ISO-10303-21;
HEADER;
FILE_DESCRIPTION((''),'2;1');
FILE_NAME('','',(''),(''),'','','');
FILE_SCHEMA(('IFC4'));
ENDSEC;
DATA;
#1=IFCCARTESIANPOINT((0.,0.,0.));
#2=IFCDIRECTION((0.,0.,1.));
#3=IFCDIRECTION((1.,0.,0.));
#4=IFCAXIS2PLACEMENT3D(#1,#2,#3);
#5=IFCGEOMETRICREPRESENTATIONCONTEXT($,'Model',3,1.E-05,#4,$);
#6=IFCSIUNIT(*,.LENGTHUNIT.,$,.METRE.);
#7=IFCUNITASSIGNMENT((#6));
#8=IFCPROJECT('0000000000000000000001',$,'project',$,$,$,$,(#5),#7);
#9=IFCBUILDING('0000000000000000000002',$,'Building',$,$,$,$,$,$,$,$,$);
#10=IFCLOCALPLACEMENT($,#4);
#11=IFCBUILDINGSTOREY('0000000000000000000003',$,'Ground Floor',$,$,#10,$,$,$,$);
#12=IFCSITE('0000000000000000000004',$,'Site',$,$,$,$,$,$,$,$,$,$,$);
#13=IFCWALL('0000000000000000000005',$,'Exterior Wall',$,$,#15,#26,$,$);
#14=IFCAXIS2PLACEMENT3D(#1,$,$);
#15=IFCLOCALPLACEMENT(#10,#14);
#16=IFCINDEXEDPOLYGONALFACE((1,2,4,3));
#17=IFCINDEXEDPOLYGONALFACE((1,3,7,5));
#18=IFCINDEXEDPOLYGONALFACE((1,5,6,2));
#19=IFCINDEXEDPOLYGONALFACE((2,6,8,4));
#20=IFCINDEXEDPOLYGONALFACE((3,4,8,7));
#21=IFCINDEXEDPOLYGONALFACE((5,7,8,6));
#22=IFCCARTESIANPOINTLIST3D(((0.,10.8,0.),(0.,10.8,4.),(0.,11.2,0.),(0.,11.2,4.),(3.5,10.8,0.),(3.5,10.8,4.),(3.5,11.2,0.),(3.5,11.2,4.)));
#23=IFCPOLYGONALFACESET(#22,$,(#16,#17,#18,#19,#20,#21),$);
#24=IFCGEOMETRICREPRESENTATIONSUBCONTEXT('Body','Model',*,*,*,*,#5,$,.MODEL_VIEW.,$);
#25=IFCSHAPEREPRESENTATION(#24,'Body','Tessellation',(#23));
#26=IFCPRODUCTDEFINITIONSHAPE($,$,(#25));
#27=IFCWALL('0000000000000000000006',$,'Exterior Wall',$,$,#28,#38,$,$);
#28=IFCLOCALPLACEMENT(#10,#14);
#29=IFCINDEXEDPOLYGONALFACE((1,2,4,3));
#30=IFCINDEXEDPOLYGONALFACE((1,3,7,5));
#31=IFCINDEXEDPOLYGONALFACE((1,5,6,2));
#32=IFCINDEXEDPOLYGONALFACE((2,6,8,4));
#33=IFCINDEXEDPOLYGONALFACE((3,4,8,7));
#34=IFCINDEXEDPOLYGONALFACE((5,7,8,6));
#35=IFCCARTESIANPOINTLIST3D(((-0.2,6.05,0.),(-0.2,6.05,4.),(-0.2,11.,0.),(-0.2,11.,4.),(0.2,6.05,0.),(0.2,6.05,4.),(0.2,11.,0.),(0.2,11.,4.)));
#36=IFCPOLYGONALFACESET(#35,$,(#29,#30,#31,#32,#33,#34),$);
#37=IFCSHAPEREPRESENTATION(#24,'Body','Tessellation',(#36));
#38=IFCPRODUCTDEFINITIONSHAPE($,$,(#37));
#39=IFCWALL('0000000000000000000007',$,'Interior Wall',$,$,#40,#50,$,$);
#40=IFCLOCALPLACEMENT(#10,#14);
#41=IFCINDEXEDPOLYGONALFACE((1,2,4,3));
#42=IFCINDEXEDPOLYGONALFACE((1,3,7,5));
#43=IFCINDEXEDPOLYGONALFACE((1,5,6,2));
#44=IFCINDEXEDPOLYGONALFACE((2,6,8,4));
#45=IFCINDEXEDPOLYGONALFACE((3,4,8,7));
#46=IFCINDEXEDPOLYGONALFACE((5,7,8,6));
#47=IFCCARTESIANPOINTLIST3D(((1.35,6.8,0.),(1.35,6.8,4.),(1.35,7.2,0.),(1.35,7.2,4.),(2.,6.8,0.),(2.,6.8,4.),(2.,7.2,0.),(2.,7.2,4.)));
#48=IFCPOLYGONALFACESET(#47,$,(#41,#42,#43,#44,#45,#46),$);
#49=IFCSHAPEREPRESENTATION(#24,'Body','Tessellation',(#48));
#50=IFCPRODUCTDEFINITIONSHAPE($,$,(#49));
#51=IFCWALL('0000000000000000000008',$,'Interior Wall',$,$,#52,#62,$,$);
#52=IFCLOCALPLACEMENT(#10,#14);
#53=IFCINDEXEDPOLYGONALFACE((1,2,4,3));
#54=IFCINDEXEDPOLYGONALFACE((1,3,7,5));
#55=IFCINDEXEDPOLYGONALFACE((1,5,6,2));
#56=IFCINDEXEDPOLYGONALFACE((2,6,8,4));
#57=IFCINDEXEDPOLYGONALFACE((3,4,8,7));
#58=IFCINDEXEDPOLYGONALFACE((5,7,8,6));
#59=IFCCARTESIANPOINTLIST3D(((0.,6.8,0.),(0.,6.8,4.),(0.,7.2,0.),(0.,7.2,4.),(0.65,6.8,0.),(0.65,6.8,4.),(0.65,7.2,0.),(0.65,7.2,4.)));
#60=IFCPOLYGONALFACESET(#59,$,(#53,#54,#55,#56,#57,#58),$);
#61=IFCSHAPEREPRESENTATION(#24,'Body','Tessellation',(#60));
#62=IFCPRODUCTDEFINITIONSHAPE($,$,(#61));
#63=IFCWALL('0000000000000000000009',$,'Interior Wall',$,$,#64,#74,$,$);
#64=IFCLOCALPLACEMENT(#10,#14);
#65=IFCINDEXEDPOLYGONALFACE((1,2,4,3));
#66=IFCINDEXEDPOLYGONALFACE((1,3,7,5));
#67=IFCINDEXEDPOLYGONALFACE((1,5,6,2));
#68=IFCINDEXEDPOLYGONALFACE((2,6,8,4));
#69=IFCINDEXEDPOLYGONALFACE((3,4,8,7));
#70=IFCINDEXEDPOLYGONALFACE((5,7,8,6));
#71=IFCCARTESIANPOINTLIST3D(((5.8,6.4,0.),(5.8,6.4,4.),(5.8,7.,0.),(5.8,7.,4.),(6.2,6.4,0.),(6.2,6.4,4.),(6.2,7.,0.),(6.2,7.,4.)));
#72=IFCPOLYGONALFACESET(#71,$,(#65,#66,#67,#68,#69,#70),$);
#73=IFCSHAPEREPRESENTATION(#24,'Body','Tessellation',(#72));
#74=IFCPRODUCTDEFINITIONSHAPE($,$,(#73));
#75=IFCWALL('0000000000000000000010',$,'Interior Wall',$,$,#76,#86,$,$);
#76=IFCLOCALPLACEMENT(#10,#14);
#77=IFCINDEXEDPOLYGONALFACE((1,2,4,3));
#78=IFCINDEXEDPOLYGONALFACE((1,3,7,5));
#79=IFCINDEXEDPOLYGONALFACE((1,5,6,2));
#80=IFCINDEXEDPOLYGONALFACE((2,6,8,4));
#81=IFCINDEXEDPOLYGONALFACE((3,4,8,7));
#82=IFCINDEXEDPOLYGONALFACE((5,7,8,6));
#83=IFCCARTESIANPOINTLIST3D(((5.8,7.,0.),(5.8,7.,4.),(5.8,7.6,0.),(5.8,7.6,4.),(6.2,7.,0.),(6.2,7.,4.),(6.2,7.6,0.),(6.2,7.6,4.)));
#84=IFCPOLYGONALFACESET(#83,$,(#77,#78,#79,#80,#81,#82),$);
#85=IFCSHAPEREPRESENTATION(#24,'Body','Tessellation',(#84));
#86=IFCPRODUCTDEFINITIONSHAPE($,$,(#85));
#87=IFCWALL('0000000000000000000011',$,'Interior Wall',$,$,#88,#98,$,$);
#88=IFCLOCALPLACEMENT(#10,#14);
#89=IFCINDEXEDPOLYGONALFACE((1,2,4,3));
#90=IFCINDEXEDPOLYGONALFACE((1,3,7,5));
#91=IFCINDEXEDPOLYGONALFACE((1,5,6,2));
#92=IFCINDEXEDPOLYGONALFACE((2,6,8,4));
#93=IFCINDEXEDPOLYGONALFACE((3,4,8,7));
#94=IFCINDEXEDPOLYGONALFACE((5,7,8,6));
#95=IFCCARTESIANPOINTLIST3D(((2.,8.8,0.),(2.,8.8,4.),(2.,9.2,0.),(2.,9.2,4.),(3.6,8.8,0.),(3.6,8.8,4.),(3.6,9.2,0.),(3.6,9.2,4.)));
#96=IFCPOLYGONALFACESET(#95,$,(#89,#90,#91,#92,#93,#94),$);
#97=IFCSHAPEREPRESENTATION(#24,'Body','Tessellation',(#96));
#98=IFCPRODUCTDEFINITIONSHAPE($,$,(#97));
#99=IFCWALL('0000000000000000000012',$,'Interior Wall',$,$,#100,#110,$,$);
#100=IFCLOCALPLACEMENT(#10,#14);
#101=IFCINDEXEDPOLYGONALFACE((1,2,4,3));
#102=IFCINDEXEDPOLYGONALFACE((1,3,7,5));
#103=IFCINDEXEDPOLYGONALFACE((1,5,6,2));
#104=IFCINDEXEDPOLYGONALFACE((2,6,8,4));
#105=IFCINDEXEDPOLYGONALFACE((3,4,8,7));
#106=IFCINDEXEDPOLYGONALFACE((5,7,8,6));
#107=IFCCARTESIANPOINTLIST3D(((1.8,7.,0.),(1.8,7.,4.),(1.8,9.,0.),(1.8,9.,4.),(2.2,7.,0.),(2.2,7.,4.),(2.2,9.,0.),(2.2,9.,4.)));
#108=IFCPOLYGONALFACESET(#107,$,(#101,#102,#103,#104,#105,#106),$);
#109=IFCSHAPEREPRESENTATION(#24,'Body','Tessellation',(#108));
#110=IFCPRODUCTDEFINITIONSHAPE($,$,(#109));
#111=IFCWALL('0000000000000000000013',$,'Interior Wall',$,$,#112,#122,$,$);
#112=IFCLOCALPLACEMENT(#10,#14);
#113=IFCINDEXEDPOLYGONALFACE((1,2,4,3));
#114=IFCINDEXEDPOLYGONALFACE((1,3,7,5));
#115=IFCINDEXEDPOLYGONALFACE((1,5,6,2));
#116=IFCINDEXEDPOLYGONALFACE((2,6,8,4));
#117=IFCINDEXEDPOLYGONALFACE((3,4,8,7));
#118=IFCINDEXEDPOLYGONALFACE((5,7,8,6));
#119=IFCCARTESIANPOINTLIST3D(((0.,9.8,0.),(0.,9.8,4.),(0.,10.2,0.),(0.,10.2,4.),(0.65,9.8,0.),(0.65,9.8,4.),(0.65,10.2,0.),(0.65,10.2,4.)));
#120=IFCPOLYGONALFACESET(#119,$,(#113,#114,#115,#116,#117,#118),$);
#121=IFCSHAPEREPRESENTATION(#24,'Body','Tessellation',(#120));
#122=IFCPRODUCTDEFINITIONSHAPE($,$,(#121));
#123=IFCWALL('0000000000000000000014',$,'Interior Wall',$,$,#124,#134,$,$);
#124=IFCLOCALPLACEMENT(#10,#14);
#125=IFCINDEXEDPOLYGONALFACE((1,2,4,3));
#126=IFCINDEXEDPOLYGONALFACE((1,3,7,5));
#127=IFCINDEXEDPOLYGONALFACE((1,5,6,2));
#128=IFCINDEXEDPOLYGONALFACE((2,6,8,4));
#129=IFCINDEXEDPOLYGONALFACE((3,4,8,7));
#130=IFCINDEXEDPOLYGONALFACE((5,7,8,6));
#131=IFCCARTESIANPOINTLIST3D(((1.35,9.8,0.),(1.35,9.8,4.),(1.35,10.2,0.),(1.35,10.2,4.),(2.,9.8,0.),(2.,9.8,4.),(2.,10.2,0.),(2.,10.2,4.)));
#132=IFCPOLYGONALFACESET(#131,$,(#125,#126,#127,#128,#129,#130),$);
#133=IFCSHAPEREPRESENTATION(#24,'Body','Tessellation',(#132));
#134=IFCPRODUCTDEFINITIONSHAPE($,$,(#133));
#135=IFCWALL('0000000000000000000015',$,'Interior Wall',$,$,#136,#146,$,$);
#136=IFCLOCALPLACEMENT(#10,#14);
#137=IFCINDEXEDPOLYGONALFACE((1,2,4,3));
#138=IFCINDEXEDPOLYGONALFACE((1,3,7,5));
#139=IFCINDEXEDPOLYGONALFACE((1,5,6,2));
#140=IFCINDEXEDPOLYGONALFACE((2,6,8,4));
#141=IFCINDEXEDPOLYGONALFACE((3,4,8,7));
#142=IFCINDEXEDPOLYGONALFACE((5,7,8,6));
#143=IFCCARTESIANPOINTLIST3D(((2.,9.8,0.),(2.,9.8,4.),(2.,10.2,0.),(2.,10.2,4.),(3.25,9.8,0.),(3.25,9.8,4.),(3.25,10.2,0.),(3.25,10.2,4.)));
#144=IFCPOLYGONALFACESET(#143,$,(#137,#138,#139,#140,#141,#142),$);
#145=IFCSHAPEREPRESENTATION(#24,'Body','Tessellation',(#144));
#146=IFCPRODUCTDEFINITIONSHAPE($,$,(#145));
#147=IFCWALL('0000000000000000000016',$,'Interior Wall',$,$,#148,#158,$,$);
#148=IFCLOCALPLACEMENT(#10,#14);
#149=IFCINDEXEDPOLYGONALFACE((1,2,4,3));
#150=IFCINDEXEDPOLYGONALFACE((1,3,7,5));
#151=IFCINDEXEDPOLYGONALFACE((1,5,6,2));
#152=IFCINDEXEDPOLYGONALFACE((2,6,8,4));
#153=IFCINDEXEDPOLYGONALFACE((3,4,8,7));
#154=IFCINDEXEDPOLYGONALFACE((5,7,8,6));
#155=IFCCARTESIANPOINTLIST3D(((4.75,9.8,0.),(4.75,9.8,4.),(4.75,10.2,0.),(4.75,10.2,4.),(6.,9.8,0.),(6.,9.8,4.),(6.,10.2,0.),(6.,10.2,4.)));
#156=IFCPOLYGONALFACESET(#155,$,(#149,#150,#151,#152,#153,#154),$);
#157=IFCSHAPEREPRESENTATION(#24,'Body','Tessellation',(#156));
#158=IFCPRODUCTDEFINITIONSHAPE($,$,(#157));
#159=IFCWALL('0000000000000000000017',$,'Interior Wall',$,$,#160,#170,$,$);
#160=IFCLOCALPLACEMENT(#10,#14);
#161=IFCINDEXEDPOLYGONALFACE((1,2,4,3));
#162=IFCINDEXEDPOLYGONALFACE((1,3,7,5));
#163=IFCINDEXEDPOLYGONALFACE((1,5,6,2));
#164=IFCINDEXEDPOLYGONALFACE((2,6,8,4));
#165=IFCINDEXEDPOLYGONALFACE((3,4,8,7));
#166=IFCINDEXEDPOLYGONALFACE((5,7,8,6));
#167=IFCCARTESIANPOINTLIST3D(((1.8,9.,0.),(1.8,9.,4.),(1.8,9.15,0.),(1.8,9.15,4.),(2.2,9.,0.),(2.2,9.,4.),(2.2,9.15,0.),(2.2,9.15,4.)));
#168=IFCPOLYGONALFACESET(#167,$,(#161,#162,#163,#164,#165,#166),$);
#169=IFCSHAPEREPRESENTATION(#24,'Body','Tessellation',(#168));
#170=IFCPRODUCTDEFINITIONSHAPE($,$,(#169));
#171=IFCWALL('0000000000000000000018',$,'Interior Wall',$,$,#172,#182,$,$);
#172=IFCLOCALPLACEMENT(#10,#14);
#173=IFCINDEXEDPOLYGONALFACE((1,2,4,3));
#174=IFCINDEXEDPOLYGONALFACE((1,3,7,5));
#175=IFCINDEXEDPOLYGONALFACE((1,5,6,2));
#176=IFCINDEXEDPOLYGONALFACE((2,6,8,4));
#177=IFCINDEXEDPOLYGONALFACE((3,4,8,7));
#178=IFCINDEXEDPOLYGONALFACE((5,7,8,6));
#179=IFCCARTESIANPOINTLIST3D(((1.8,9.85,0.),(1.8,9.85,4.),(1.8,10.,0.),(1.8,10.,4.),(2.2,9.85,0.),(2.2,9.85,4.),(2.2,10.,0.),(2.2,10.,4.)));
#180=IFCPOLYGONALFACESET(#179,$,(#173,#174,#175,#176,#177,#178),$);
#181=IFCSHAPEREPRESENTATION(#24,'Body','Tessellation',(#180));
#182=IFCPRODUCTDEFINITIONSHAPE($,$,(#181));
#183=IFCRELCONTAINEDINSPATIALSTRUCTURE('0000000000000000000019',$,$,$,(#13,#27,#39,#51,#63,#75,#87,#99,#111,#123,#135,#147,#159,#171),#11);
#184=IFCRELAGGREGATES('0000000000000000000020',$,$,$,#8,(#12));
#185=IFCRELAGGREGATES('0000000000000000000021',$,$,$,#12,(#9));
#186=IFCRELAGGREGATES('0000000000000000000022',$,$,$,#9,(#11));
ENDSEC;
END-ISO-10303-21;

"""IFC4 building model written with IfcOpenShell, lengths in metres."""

from ifc_helpers import new_model, si_unit, frame, origin_with_axes, place, context, subcontext, project, spatial, indexed_curve, outline, extrude, element, save


model = new_model("IFC4")

# Units and contexts
model_context = context("Model", 3, precision=1e-05, world=origin_with_axes())
body_context = subcontext(model_context, "Body", "Model", "MODEL_VIEW")
ifc_project = project(units=[si_unit("LENGTHUNIT", "METRE")], contexts=[model_context])

# Site, building, storey
site = spatial("IfcSite", under=ifc_project, Name="Site")
building = spatial("IfcBuilding", under=site, Name="Building")
storey_placement = place(None, origin_with_axes())
storey = spatial("IfcBuildingStorey", under=building, at=storey_placement, Name="Ground Floor")

# Walls
wall_1_placement = place(storey_placement, frame((3.5, 11.0, 0.0), z_axis=(0.0, 0.0, 1.0), x_axis=(-1.0, 0.0, 0.0)))
element("IfcWall", 1, at=wall_1_placement, inside=storey, Name="Exterior Wall", context=body_context, shape_type="SweptSolid", body=[
    extrude(outline(indexed_curve([(0.0, 0.0), (0.0, 0.4), (3.5, 0.4), (3.5, 0.0), (0.0, 0.0)], self_intersect=False)), frame((0.0, -0.2, 0.0), z_axis=(0.0, 0.0, 1.0), x_axis=(1.0, 0.0, 0.0)), (0.0, 0.0, 1.0), 4.0),
])
wall_2_placement = place(storey_placement, frame((0.0, 11.0, 0.0), z_axis=(0.0, 0.0, 1.0), x_axis=(0.0, -1.0, 0.0)))
element("IfcWall", 2, at=wall_2_placement, inside=storey, Name="Exterior Wall", context=body_context, shape_type="SweptSolid", body=[
    extrude(outline(indexed_curve([(0.0, 0.0), (0.0, 0.4), (4.95, 0.4), (4.95, 0.0), (0.0, 0.0)], self_intersect=False)), frame((0.0, -0.2, 0.0), z_axis=(0.0, 0.0, 1.0), x_axis=(1.0, 0.0, 0.0)), (0.0, 0.0, 1.0), 4.0),
])
for number, where, z_axis, x_axis, name in (
    (3, (2.0, 7.0, 0.0), (0.0, 0.0, 1.0), (-1.0, 0.0, 0.0), "Interior Wall"),
    (4, (0.65, 7.0, 0.0), (0.0, 0.0, 1.0), (-1.0, 0.0, 0.0), "Interior Wall"),
):
    element("IfcWall", number, at=place(storey_placement, frame(where, z_axis=z_axis, x_axis=x_axis)), inside=storey, Name=name, context=body_context, shape_type="SweptSolid", body=[
        extrude(outline(indexed_curve([(0.0, 0.0), (0.0, 0.4), (0.65, 0.4), (0.65, 0.0), (0.0, 0.0)], self_intersect=False)), frame((0.0, -0.2, 0.0), z_axis=(0.0, 0.0, 1.0), x_axis=(1.0, 0.0, 0.0)), (0.0, 0.0, 1.0), 4.0),
    ])
for number, where, z_axis, x_axis, name in (
    (5, (6.0, 6.4, 0.0), (0.0, 0.0, 1.0), (0.0, 1.0, 0.0), "Interior Wall"),
    (6, (6.0, 7.0, 0.0), (0.0, 0.0, 1.0), (0.0, 1.0, 0.0), "Interior Wall"),
):
    element("IfcWall", number, at=place(storey_placement, frame(where, z_axis=z_axis, x_axis=x_axis)), inside=storey, Name=name, context=body_context, shape_type="SweptSolid", body=[
        extrude(outline(indexed_curve([(0.0, 0.0), (0.0, 0.4), (0.6, 0.4), (0.6, 0.0), (0.0, 0.0)], self_intersect=False)), frame((0.0, -0.2, 0.0), z_axis=(0.0, 0.0, 1.0), x_axis=(1.0, 0.0, 0.0)), (0.0, 0.0, 1.0), 4.0),
    ])
wall_3_placement = place(storey_placement, frame((3.6, 9.0, 0.0), z_axis=(0.0, 0.0, 1.0), x_axis=(-1.0, 0.0, 0.0)))
element("IfcWall", 7, at=wall_3_placement, inside=storey, Name="Interior Wall", context=body_context, shape_type="SweptSolid", body=[
    extrude(outline(indexed_curve([(0.0, 0.0), (0.0, 0.4), (1.6, 0.4), (1.6, 0.0), (0.0, 0.0)], self_intersect=False)), frame((0.0, -0.2, 0.0), z_axis=(0.0, 0.0, 1.0), x_axis=(1.0, 0.0, 0.0)), (0.0, 0.0, 1.0), 4.0),
])
wall_4_placement = place(storey_placement, frame((2.0, 9.0, 0.0), z_axis=(0.0, 0.0, 1.0), x_axis=(0.0, -1.0, 0.0)))
element("IfcWall", 8, at=wall_4_placement, inside=storey, Name="Interior Wall", context=body_context, shape_type="SweptSolid", body=[
    extrude(outline(indexed_curve([(0.0, 0.0), (0.0, 0.4), (2.0, 0.4), (2.0, 0.0), (0.0, 0.0)], self_intersect=False)), frame((0.0, -0.2, 0.0), z_axis=(0.0, 0.0, 1.0), x_axis=(1.0, 0.0, 0.0)), (0.0, 0.0, 1.0), 4.0),
])
wall_5_placement = place(storey_placement, frame((0.0, 10.0, 0.0), z_axis=(0.0, 0.0, 1.0), x_axis=(1.0, 0.0, 0.0)))
element("IfcWall", 9, at=wall_5_placement, inside=storey, Name="Interior Wall", context=body_context, shape_type="SweptSolid", body=[
    extrude(outline(indexed_curve([(0.0, 0.0), (0.0, 0.4), (0.65, 0.4), (0.65, 0.0), (0.0, 0.0)], self_intersect=False)), frame((0.0, -0.2, 0.0), z_axis=(0.0, 0.0, 1.0), x_axis=(1.0, 0.0, 0.0)), (0.0, 0.0, 1.0), 4.0),
])
wall_6_placement = place(storey_placement, frame((1.35, 10.0, 0.0), z_axis=(0.0, 0.0, 1.0), x_axis=(1.0, 0.0, 0.0)))
element("IfcWall", 10, at=wall_6_placement, inside=storey, Name="Interior Wall", context=body_context, shape_type="SweptSolid", body=[
    extrude(outline(indexed_curve([(0.0, 0.0), (0.0, 0.4), (0.65, 0.4), (0.65, 0.0), (0.0, 0.0)], self_intersect=False)), frame((0.0, -0.2, 0.0), z_axis=(0.0, 0.0, 1.0), x_axis=(1.0, 0.0, 0.0)), (0.0, 0.0, 1.0), 4.0),
])
for number, where, z_axis, x_axis, name in (
    (11, (2.0, 10.0, 0.0), (0.0, 0.0, 1.0), (1.0, 0.0, 0.0), "Interior Wall"),
    (12, (4.75, 10.0, 0.0), (0.0, 0.0, 1.0), (1.0, 0.0, 0.0), "Interior Wall"),
):
    element("IfcWall", number, at=place(storey_placement, frame(where, z_axis=z_axis, x_axis=x_axis)), inside=storey, Name=name, context=body_context, shape_type="SweptSolid", body=[
        extrude(outline(indexed_curve([(0.0, 0.0), (0.0, 0.4), (1.25, 0.4), (1.25, 0.0), (0.0, 0.0)], self_intersect=False)), frame((0.0, -0.2, 0.0), z_axis=(0.0, 0.0, 1.0), x_axis=(1.0, 0.0, 0.0)), (0.0, 0.0, 1.0), 4.0),
    ])
for number, where, z_axis, x_axis, name in (
    (13, (2.0, 9.0, 0.0), (0.0, 0.0, 1.0), (0.0, 1.0, 0.0), "Interior Wall"),
    (14, (2.0, 9.85, 0.0), (0.0, 0.0, 1.0), (0.0, 1.0, 0.0), "Interior Wall"),
):
    element("IfcWall", number, at=place(storey_placement, frame(where, z_axis=z_axis, x_axis=x_axis)), inside=storey, Name=name, context=body_context, shape_type="SweptSolid", body=[
        extrude(outline(indexed_curve([(0.0, 0.0), (0.0, 0.4), (0.15, 0.4), (0.15, 0.0), (0.0, 0.0)], self_intersect=False)), frame((0.0, -0.2, 0.0), z_axis=(0.0, 0.0, 1.0), x_axis=(1.0, 0.0, 0.0)), (0.0, 0.0, 1.0), 4.0),
    ])

save(model, "model.ifc")
